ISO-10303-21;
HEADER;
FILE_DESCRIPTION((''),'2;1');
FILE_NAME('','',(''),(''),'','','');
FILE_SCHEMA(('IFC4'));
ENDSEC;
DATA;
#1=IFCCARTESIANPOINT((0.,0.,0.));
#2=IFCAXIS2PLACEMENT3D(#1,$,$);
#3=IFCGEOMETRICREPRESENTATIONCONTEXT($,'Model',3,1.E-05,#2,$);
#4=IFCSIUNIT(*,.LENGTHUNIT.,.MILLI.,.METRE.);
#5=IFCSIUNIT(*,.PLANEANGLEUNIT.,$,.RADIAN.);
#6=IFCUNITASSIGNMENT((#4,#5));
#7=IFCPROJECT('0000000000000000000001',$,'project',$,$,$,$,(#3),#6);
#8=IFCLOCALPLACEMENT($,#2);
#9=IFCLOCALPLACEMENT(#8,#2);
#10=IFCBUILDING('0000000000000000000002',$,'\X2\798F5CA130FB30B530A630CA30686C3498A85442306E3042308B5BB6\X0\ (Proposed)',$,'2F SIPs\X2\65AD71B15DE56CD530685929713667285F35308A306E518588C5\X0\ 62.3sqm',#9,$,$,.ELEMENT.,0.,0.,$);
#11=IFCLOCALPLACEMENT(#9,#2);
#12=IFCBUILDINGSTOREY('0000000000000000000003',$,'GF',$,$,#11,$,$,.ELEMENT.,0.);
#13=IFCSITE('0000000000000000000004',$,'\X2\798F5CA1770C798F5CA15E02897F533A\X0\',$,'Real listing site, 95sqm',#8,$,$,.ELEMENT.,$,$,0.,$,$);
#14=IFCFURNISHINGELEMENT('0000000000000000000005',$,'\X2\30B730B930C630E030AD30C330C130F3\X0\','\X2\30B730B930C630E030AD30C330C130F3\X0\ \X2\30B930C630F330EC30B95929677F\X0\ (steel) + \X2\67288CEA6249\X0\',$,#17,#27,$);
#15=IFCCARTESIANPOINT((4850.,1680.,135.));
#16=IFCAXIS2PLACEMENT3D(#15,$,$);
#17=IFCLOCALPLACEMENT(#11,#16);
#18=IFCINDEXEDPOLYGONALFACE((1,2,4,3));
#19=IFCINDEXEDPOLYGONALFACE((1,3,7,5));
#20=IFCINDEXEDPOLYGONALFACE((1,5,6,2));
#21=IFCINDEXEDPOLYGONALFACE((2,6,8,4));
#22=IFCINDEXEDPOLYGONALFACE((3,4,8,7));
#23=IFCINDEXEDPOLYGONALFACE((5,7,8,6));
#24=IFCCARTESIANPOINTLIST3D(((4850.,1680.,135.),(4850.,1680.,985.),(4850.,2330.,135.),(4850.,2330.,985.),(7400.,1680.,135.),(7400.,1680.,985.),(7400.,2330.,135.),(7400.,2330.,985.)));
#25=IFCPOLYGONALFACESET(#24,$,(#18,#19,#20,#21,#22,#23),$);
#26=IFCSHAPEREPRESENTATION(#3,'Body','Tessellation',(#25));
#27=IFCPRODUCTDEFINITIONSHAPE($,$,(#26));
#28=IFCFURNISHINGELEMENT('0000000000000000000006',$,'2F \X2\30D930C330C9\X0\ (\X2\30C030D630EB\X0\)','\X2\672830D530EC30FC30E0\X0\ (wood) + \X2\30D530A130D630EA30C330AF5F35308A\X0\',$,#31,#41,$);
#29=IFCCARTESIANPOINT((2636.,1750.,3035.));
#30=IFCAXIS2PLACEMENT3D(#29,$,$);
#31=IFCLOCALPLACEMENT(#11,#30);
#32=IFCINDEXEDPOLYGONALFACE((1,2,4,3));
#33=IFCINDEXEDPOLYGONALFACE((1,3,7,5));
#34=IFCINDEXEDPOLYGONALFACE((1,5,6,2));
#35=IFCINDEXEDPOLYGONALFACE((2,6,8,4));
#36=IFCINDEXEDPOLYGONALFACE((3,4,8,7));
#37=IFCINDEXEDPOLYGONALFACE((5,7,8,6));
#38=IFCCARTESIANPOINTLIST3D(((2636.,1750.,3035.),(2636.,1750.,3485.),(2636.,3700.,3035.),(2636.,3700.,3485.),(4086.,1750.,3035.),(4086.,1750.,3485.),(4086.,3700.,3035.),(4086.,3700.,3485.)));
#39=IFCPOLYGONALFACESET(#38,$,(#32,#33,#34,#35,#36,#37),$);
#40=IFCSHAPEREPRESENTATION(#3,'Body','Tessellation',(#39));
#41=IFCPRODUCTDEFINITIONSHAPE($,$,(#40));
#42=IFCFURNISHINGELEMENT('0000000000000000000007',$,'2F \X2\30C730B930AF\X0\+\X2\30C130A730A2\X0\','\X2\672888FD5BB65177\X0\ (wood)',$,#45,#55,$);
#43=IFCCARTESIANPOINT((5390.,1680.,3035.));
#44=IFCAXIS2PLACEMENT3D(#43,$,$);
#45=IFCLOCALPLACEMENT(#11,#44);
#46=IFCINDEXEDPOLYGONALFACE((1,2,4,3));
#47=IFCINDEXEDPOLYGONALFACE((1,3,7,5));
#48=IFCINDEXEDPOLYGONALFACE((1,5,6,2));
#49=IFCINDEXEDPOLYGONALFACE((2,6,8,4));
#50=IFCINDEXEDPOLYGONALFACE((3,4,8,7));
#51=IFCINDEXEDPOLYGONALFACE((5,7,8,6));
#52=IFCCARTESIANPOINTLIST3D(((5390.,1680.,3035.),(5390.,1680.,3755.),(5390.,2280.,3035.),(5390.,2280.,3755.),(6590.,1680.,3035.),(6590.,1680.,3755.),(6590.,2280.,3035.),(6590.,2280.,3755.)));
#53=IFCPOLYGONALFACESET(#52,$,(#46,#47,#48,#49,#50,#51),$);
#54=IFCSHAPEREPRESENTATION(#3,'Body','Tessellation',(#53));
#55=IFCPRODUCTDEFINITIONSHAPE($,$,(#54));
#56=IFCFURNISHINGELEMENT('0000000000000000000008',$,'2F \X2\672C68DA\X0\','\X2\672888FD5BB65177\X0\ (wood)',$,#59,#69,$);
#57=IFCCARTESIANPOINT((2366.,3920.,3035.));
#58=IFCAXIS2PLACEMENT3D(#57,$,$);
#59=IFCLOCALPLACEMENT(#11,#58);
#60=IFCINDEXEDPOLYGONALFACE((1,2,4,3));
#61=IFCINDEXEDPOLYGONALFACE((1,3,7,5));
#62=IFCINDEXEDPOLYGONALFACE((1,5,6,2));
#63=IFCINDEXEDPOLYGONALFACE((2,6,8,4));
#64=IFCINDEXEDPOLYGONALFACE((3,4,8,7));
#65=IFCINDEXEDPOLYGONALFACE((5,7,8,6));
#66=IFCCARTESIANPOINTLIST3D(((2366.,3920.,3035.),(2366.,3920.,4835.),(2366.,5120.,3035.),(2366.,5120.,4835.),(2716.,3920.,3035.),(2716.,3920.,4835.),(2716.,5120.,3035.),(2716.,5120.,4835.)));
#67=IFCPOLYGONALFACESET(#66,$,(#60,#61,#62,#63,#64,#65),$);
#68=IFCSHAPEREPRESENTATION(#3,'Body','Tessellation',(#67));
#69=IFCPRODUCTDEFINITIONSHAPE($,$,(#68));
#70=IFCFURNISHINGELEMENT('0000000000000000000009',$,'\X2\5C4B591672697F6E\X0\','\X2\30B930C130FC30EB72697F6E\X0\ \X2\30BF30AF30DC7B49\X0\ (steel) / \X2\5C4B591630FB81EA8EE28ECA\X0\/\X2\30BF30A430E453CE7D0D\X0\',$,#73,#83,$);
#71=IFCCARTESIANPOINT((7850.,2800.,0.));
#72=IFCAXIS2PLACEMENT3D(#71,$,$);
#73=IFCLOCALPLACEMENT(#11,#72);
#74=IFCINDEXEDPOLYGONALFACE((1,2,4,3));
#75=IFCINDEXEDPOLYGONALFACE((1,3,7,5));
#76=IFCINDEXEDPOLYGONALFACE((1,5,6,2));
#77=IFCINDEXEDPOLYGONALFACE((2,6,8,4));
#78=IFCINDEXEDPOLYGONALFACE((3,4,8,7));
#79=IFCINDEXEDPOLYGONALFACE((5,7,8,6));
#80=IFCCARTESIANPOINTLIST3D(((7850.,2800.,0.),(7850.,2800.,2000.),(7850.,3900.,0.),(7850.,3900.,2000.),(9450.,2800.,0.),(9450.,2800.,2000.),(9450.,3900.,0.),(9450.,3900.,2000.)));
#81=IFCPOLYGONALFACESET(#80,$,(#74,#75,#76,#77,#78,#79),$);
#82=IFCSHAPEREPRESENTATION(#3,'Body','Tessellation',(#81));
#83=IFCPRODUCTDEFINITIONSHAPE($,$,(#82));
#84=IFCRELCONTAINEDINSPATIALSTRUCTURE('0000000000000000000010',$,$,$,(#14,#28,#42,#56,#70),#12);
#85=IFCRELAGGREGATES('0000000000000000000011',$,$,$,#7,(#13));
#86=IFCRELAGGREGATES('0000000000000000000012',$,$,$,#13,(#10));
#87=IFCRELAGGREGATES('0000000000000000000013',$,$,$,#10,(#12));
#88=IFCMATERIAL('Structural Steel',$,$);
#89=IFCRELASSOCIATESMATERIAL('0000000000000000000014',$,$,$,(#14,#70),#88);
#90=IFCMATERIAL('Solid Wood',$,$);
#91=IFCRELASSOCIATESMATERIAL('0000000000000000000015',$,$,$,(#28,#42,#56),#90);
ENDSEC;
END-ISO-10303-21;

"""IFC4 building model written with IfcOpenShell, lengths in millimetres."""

from ifc_helpers import new_model, si_unit, frame, frame_2d, origin, place, context, project, spatial, rectangle, extrude, material, element, save


model = new_model("IFC4")

# Units and contexts
model_context = context("Model", 3, precision=1e-05, world=origin())
ifc_project = project(units=[si_unit("LENGTHUNIT", "METRE", prefix="MILLI"), si_unit("PLANEANGLEUNIT", "RADIAN")], contexts=[model_context])

# Site, building, storey
site_placement = place(None, origin())
site = spatial("IfcSite", under=ifc_project, at=site_placement, Name="福岡県福岡市西区", ObjectType="Real listing site, 95sqm", CompositionType="ELEMENT", RefElevation=0.0)
building_placement = place(site_placement, origin())
building = spatial("IfcBuilding", under=site, at=building_placement, Name="福岡・サウナと水風呂のある家 (Proposed)", ObjectType="2F SIPs断熱工法と天然木張りの内装 62.3sqm", CompositionType="ELEMENT", ElevationOfRefHeight=0.0, ElevationOfTerrain=0.0)
storey_placement = place(building_placement, origin())
storey = spatial("IfcBuildingStorey", under=building, at=storey_placement, Name="GF", CompositionType="ELEMENT", Elevation=0.0)

# Shared definitions
ifc_material_1 = material(Name="Solid Wood")

# Shared definitions
ifc_material_2 = material(Name="Structural Steel")

# Furnishing elements
furnishing_1_placement = place(storey_placement, frame((4850.0, 1680.0, 135.0)))
element("IfcFurnishingElement", 1, at=furnishing_1_placement, inside=storey, material=ifc_material_2, Name="システムキッチン", Description="システムキッチン ステンレス天板 (steel) + 木質扉", context=model_context, shape_type="SweptSolid", body=[
    extrude(rectangle(XDim=2550.0, YDim=650.0, at=frame_2d((1275.0, 325.0))), frame((4850.0, 1680.0, 135.0)), (0.0, 0.0, 1.0), 850.0),
])
furnishing_2_placement = place(storey_placement, frame((2636.0, 1750.0, 3035.0)))
element("IfcFurnishingElement", 2, at=furnishing_2_placement, inside=storey, material=ifc_material_1, Name="2F ベッド (ダブル)", Description="木フレーム (wood) + ファブリック張り", context=model_context, shape_type="SweptSolid", body=[
    extrude(rectangle(XDim=1450.0, YDim=1950.0, at=frame_2d((725.0, 975.0))), frame((2636.0, 1750.0, 3035.0)), (0.0, 0.0, 1.0), 450.0),
])
furnishing_3_placement = place(storey_placement, frame((5390.0, 1680.0, 3035.0)))
element("IfcFurnishingElement", 3, at=furnishing_3_placement, inside=storey, material=ifc_material_1, Name="2F デスク+チェア", Description="木製家具 (wood)", context=model_context, shape_type="SweptSolid", body=[
    extrude(rectangle(XDim=1200.0, YDim=600.0, at=frame_2d((600.0, 300.0))), frame((5390.0, 1680.0, 3035.0)), (0.0, 0.0, 1.0), 720.0),
])
furnishing_4_placement = place(storey_placement, frame((2366.0, 3920.0, 3035.0)))
element("IfcFurnishingElement", 4, at=furnishing_4_placement, inside=storey, material=ifc_material_1, Name="2F 本棚", Description="木製家具 (wood)", context=model_context, shape_type="SweptSolid", body=[
    extrude(rectangle(XDim=350.0, YDim=1200.0, at=frame_2d((175.0, 600.0))), frame((2366.0, 3920.0, 3035.0)), (0.0, 0.0, 1.0), 1800.0),
])
furnishing_5_placement = place(storey_placement, frame((7850.0, 2800.0, 0.0)))
element("IfcFurnishingElement", 5, at=furnishing_5_placement, inside=storey, material=ifc_material_2, Name="屋外物置", Description="スチール物置 タクボ等 (steel) / 屋外・自転車/タイヤ収納", context=model_context, shape_type="SweptSolid", body=[
    extrude(rectangle(XDim=1600.0, YDim=1100.0, at=frame_2d((800.0, 550.0))), frame((7850.0, 2800.0, 0.0)), (0.0, 0.0, 1.0), 2000.0),
])

save(model, "model.ifc")
